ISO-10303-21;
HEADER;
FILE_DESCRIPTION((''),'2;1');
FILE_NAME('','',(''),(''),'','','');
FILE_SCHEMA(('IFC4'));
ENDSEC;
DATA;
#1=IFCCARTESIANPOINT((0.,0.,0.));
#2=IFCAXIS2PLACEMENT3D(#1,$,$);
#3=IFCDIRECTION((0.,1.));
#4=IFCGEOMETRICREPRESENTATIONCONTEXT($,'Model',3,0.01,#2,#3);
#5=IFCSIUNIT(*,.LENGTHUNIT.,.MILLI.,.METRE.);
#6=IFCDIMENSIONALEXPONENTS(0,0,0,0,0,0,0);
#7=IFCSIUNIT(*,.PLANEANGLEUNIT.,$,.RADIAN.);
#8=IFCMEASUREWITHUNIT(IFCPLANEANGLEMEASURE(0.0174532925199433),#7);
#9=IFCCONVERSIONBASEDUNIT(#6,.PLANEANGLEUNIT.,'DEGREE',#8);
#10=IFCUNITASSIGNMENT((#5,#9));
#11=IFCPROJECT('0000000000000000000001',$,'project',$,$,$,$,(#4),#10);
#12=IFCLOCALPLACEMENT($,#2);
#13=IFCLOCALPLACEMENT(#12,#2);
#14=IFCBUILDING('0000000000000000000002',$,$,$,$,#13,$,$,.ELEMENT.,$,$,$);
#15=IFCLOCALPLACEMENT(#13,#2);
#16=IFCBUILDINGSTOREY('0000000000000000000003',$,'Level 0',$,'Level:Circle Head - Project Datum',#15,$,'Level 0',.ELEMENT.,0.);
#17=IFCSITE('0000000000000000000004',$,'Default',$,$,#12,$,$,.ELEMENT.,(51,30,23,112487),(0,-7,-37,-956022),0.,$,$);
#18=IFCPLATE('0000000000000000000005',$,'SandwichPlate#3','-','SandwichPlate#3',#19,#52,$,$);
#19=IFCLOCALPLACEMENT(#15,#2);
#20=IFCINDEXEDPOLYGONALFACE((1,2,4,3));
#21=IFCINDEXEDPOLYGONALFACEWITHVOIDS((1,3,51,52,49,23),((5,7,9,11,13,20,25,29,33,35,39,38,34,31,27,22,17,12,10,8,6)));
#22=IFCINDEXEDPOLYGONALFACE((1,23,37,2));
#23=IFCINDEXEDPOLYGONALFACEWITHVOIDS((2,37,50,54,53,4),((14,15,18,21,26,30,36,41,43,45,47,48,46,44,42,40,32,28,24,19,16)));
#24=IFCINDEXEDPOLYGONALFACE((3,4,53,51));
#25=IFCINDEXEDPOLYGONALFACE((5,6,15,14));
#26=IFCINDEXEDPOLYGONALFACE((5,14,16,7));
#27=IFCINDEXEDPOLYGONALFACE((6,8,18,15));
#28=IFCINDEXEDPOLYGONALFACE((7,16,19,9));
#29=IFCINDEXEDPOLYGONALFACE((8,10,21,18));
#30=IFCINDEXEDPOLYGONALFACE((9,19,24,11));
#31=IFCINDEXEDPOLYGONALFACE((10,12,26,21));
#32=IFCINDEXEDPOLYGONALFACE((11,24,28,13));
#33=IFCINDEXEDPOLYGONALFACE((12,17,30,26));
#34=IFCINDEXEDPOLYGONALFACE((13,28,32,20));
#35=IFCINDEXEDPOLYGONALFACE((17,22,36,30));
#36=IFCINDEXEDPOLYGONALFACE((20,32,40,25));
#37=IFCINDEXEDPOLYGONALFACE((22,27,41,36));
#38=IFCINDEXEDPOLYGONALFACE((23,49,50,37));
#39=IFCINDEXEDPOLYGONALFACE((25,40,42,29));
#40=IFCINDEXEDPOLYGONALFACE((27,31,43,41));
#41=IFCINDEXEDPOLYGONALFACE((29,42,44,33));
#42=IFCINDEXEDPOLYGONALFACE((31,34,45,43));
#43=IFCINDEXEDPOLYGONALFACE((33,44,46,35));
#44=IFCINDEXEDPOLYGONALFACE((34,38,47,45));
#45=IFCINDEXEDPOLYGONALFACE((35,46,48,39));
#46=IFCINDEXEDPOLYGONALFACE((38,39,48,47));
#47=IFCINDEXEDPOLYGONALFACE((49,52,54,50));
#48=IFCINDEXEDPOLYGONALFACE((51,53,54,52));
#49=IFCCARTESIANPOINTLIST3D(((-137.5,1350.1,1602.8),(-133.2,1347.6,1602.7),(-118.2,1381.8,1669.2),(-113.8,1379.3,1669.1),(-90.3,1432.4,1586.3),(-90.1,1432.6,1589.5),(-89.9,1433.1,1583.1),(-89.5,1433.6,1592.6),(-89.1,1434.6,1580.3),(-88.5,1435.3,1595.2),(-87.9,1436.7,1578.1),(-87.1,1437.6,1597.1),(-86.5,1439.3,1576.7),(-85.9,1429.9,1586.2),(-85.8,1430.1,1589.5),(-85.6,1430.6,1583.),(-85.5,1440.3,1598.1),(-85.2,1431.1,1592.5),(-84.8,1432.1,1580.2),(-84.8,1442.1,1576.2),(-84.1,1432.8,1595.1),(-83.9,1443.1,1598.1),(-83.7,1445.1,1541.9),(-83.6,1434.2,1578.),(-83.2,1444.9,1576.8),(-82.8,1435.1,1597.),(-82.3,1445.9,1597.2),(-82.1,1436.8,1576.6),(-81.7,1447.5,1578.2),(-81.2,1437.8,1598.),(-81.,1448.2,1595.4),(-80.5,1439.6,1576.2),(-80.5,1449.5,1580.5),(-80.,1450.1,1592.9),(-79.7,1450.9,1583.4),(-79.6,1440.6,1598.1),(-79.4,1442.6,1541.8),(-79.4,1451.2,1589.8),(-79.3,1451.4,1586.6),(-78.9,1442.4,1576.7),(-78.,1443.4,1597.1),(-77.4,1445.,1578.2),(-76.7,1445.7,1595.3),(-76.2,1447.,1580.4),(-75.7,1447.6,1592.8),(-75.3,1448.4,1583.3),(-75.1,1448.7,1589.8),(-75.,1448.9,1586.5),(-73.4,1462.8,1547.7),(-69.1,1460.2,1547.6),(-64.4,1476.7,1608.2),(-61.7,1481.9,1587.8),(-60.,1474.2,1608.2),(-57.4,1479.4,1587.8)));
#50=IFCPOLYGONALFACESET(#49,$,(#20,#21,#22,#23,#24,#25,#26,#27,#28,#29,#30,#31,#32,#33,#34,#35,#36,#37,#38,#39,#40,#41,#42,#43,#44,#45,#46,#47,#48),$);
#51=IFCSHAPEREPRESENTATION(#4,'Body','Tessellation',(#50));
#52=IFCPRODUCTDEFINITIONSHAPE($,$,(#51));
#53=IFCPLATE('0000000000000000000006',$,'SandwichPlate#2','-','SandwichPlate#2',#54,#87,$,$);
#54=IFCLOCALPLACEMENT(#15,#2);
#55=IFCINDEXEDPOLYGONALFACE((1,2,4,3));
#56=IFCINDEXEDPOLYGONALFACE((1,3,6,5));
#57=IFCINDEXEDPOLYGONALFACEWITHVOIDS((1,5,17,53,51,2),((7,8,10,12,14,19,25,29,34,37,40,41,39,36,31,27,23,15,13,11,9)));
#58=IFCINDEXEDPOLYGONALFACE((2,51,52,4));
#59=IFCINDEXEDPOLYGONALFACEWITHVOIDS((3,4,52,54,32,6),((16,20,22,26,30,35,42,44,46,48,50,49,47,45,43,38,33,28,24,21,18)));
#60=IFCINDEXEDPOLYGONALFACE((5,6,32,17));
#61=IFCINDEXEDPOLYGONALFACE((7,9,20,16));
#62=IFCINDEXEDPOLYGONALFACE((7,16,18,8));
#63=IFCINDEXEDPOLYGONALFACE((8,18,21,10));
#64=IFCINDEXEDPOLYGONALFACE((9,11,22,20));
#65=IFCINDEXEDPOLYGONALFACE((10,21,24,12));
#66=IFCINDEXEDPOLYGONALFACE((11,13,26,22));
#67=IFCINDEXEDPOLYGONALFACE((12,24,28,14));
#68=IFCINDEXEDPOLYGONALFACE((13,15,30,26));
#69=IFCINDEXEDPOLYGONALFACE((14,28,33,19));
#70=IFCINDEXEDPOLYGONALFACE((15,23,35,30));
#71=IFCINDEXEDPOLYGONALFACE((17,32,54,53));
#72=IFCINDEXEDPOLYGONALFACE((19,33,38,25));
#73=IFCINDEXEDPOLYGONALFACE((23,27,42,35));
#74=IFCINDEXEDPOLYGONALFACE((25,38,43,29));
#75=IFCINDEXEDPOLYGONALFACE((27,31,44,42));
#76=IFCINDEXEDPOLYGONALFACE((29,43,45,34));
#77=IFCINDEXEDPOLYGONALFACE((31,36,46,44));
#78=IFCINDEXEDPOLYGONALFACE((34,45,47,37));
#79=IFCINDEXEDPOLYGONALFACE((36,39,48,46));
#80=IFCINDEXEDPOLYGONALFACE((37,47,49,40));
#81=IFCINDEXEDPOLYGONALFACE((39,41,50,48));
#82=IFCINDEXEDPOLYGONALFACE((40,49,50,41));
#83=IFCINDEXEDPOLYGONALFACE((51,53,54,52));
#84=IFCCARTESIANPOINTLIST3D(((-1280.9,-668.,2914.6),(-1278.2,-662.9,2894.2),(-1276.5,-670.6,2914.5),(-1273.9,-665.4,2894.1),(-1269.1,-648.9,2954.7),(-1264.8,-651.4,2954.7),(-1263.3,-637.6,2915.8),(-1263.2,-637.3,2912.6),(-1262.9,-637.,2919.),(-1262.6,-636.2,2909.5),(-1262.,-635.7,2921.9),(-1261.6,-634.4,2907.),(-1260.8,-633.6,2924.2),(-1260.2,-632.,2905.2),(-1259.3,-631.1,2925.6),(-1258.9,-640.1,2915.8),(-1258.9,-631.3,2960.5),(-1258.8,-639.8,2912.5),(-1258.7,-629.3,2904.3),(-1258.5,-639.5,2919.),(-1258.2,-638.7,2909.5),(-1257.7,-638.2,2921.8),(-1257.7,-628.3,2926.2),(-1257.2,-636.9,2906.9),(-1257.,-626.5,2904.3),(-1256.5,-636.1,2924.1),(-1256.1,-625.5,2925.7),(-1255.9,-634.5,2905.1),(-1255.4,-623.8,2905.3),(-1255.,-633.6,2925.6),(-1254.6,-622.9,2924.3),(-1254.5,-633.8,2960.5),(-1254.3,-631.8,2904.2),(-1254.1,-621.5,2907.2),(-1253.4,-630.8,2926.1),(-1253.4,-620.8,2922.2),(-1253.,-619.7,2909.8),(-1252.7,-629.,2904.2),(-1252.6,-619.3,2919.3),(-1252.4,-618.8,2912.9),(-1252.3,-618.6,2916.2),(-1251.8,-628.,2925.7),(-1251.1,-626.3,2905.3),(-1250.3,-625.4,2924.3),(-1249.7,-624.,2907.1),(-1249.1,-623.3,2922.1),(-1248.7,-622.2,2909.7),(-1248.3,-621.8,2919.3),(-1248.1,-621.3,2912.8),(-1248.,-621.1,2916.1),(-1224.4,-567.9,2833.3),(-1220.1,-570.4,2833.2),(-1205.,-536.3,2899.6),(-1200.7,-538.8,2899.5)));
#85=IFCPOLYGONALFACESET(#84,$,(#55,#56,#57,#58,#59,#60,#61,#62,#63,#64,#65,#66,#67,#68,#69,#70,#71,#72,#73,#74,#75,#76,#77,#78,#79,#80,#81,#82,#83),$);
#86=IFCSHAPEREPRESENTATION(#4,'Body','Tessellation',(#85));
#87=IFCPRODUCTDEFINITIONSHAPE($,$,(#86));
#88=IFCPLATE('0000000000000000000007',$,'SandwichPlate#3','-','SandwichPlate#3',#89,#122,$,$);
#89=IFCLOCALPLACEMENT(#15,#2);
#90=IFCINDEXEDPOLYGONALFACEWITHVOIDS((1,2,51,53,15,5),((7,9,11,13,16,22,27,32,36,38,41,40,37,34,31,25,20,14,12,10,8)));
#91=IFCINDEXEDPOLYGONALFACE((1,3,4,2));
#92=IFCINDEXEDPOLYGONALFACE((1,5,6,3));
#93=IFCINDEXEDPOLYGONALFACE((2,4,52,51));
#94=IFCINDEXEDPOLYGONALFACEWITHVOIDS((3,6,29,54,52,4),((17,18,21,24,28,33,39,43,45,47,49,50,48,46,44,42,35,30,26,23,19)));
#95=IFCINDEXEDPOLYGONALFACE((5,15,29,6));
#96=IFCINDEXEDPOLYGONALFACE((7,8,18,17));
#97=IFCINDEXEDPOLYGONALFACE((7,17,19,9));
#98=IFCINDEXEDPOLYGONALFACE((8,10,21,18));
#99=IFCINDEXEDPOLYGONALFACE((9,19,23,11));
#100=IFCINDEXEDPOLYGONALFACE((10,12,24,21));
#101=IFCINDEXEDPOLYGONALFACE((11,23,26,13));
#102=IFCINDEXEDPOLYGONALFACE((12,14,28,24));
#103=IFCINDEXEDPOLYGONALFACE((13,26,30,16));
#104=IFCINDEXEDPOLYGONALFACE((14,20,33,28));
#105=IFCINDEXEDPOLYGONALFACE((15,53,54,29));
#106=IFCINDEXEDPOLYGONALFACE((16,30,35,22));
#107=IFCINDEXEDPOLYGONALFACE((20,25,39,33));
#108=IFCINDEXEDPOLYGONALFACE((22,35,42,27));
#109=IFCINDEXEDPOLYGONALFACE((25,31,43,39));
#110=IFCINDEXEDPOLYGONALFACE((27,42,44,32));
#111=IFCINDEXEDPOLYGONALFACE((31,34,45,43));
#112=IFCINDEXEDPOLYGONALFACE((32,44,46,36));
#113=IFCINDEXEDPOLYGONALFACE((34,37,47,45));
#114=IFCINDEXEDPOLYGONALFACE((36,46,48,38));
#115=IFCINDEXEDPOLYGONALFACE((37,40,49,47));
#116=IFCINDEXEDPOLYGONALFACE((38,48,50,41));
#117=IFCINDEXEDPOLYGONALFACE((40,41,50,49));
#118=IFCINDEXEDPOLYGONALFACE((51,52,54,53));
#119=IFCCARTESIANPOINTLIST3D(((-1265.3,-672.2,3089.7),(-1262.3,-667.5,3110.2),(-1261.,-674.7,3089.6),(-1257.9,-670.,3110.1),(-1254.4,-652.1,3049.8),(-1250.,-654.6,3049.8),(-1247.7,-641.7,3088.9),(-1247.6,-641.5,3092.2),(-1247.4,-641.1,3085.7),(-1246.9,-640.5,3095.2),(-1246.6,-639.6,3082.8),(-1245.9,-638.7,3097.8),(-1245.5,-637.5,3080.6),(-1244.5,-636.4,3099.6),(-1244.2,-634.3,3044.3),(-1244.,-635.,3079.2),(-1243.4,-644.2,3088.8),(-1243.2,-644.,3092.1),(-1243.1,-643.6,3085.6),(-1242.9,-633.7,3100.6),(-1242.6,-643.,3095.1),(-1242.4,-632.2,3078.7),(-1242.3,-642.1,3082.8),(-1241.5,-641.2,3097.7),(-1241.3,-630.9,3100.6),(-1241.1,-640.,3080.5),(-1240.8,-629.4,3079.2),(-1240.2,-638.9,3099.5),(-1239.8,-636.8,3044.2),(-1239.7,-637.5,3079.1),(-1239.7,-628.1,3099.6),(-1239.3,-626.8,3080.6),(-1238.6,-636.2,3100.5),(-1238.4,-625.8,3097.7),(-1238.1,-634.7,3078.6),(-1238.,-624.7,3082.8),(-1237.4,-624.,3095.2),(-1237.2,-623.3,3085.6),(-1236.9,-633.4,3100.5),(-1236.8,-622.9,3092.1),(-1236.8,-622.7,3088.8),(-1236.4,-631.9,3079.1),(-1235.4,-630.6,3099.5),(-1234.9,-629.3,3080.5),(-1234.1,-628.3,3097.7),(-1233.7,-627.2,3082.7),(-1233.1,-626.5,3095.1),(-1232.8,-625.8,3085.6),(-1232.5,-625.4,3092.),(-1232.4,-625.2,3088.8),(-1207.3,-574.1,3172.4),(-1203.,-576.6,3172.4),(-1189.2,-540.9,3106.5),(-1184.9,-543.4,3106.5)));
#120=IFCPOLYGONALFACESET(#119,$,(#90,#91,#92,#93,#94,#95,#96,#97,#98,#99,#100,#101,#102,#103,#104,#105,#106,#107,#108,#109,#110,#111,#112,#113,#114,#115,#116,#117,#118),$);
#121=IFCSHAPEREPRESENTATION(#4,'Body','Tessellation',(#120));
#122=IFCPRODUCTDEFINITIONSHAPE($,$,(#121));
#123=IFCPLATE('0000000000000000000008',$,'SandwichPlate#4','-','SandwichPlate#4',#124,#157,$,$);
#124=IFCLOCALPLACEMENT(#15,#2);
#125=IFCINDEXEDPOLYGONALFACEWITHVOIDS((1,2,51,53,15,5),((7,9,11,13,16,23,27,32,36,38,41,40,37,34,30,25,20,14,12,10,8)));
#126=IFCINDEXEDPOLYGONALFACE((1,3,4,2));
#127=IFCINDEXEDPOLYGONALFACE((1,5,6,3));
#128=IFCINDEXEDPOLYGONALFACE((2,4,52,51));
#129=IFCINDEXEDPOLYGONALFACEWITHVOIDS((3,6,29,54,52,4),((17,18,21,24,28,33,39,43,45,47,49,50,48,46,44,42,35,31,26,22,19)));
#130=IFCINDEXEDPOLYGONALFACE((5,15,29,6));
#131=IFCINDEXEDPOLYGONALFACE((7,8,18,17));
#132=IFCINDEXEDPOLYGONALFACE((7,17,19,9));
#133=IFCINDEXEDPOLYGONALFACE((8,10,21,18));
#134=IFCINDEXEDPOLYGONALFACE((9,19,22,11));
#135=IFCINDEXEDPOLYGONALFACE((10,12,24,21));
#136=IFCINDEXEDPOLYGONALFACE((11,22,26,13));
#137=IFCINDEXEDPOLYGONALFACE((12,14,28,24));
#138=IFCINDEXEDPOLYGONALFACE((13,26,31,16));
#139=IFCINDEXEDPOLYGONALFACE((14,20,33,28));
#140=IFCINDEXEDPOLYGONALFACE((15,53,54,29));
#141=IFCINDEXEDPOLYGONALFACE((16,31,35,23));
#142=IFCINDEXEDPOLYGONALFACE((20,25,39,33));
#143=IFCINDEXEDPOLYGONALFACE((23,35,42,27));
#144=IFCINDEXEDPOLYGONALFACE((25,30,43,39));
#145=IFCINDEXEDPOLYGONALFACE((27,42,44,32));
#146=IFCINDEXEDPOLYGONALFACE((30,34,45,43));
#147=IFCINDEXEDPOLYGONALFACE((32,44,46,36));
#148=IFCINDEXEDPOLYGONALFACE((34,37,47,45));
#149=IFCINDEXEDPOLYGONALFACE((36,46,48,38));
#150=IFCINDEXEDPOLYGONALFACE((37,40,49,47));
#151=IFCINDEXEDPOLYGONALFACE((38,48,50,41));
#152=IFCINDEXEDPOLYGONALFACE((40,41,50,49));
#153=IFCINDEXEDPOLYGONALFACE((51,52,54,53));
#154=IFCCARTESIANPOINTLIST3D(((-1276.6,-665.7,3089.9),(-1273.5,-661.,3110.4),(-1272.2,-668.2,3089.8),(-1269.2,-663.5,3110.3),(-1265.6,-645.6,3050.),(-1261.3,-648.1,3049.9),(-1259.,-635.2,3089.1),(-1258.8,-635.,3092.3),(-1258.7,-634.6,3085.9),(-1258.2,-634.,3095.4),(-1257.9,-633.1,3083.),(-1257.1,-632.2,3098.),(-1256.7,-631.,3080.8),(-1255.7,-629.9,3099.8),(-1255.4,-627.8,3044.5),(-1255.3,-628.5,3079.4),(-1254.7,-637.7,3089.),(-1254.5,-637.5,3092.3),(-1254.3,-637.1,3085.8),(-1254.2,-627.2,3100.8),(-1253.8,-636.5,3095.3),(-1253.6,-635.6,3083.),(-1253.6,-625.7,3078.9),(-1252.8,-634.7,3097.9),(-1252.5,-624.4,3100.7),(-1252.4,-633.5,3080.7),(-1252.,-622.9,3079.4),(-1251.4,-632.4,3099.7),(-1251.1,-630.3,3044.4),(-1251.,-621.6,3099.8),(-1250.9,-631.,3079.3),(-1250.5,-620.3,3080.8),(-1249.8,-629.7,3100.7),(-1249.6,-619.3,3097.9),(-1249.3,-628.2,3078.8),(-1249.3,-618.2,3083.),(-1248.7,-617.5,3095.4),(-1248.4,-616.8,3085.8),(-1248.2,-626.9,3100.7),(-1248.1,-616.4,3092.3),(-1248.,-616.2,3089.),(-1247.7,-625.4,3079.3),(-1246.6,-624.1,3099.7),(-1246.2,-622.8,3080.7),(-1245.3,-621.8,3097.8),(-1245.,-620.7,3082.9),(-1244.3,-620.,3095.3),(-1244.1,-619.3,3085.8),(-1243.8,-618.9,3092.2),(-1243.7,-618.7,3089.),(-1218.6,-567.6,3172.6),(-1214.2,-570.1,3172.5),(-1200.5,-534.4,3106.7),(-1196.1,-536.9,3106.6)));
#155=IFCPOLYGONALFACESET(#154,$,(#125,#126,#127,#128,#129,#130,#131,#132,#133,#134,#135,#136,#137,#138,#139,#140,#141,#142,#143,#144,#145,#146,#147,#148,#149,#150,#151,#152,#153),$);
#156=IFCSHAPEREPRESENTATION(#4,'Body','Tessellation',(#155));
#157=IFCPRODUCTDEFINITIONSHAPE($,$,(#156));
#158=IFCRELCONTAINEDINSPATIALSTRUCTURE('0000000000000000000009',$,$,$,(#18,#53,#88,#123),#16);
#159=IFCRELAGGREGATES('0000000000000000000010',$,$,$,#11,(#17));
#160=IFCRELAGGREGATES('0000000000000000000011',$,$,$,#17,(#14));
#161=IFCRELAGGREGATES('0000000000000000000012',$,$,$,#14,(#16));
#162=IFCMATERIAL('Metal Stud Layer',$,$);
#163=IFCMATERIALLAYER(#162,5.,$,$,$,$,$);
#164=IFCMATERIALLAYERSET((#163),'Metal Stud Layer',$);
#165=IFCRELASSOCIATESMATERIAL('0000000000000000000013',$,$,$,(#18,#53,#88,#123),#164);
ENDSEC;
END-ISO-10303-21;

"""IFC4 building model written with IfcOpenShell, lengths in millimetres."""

from ifc_helpers import new_model, entity, si_unit, converted_unit, direction, frame, origin, origin_with_axes, origin_2d_with_axis, place, context, project, spatial, polyline, circle, outline, extrude, material, layer, layer_set, element, save


model = new_model("IFC4")

# Units and contexts
model_context = context("Model", 3, precision=0.01, world=origin(), true_north=direction((0.0, 1.0)))
ifc_project = project(units=[si_unit("LENGTHUNIT", "METRE", prefix="MILLI"), converted_unit("PLANEANGLEUNIT", "DEGREE", entity("IfcPlaneAngleMeasure", 0.0174532925199433), si_unit("PLANEANGLEUNIT", "RADIAN"), dimensions=[0, 0, 0, 0, 0, 0, 0])], contexts=[model_context])

# Site, building, storey
site_placement = place(None, origin())
site = spatial("IfcSite", under=ifc_project, at=site_placement, Name="Default", CompositionType="ELEMENT", RefLatitude=(51, 30, 23, 112487), RefLongitude=(0, -7, -37, -956022), RefElevation=0.0)
building_placement = place(site_placement, origin())
building = spatial("IfcBuilding", under=site, at=building_placement, CompositionType="ELEMENT")
storey_placement = place(building_placement, origin())
storey = spatial("IfcBuildingStorey", under=building, at=storey_placement, Name="Level 0", ObjectType="Level:Circle Head - Project Datum", LongName="Level 0", CompositionType="ELEMENT", Elevation=0.0)

# Plates, openings
ifc_material_1 = material(Name="Metal Stud Layer")
ifc_layer_1 = layer(ifc_material_1, 5.0)
ifc_layer_set_1 = layer_set([ifc_layer_1], Name="Metal Stud Layer")
plate_1_placement = place(storey_placement, frame((-77.2, 1456.5, 1534.6), z_axis=(0.865935, -0.499948, -0.014432), x_axis=(0.254617, 0.415806, 0.873084)))
plate_1 = element("IfcPlate", 1, at=plate_1_placement, inside=storey, material=ifc_layer_set_1, Name="SandwichPlate#3", Description="-", ObjectType="SandwichPlate#3", context=model_context, shape_type="SweptSolid", body=[
    extrude(outline(polyline([(0.0, 0.0), (76.0, 0.0), (76.0, 140.0), (0.0, 140.0), (0.0, 0.0)])), origin_with_axes(), (0.0, 0.0, 1.0), 5.0),
])
opening_1_placement = place(plate_1_placement, frame((0.0, 0.0, 0.0), z_axis=(0.0, 0.0, 1.0), x_axis=(1.0, 0.0, 0.0)))
element("IfcOpeningElement", 2, at=opening_1_placement, cuts=plate_1, ObjectType="Opening", context=model_context, shape_type="SweptSolid", body=[
    extrude(outline(polyline([(0.0, 0.0), (15.0, 0.0), (0.0, 15.0), (0.0, 0.0)])), origin(), (0.0, 0.0, 1.0), 5.0),
])
opening_2_placement = place(plate_1_placement, frame((0.0, 0.0, 0.0), z_axis=(0.0, 0.0, 1.0), x_axis=(1.0, 0.0, 0.0)))
element("IfcOpeningElement", 3, at=opening_2_placement, cuts=plate_1, ObjectType="Opening", context=model_context, shape_type="SweptSolid", body=[
    extrude(outline(polyline([(76.0, 0.0), (76.0, 15.0), (61.0, 0.0), (76.0, 0.0)])), origin(), (0.0, 0.0, 1.0), 5.0),
])
opening_3_placement = place(plate_1_placement, frame((38.0, 40.0, -0.5), z_axis=(0.0, 0.0, 1.0), x_axis=(0.0, 1.0, 0.0)))
element("IfcOpeningElement", 4, at=opening_3_placement, cuts=plate_1, ObjectType="Opening", context=model_context, shape_type="SweptSolid", body=[
    extrude(circle(Radius=11.0, at=origin_2d_with_axis()), origin(), (0.0, 0.0, 1.0), 6.0),
])
plate_2_placement = place(storey_placement, frame((-1280.3, -676.8, 2901.4), z_axis=(-0.865935, 0.499948, 0.014432), x_axis=(0.254617, 0.415806, 0.873084)))
plate_2 = element("IfcPlate", 5, at=plate_2_placement, inside=storey, material=ifc_layer_set_1, Name="SandwichPlate#2", Description="-", ObjectType="SandwichPlate#2", context=model_context, shape_type="SweptSolid", body=[
    extrude(outline(polyline([(0.0, 0.0), (76.0, 0.0), (76.0, 140.0), (0.0, 140.0), (0.0, 0.0)])), origin_with_axes(), (0.0, 0.0, 1.0), 5.0),
])
opening_4_placement = place(plate_2_placement, frame((0.0, 0.0, 0.0), z_axis=(0.0, 0.0, 1.0), x_axis=(1.0, 0.0, 0.0)))
element("IfcOpeningElement", 6, at=opening_4_placement, cuts=plate_2, ObjectType="Opening", context=model_context, shape_type="SweptSolid", body=[
    extrude(outline(polyline([(0.0, 0.0), (15.0, 0.0), (0.0, 15.0), (0.0, 0.0)])), origin(), (0.0, 0.0, 1.0), 5.0),
])
opening_5_placement = place(plate_2_placement, frame((0.0, 0.0, 0.0), z_axis=(0.0, 0.0, 1.0), x_axis=(1.0, 0.0, 0.0)))
element("IfcOpeningElement", 7, at=opening_5_placement, cuts=plate_2, ObjectType="Opening", context=model_context, shape_type="SweptSolid", body=[
    extrude(outline(polyline([(76.0, 0.0), (76.0, 15.0), (61.0, 0.0), (76.0, 0.0)])), origin(), (0.0, 0.0, 1.0), 5.0),
])
opening_6_placement = place(plate_2_placement, frame((38.0, 40.0, -0.5), z_axis=(0.0, 0.0, 1.0), x_axis=(0.0, 1.0, 0.0)))
element("IfcOpeningElement", 8, at=opening_6_placement, cuts=plate_2, ObjectType="Opening", context=model_context, shape_type="SweptSolid", body=[
    extrude(circle(Radius=11.0, at=origin_2d_with_axis()), origin(), (0.0, 0.0, 1.0), 6.0),
])
plate_3_placement = place(storey_placement, frame((-1246.4, -648.0, 3036.7), z_axis=(-0.865935, 0.499948, 0.014432), x_axis=(-0.238139, -0.437501, 0.867112)))
plate_3 = element("IfcPlate", 9, at=plate_3_placement, inside=storey, material=ifc_layer_set_1, Name="SandwichPlate#3", Description="-", ObjectType="SandwichPlate#3", context=model_context, shape_type="SweptSolid", body=[
    extrude(outline(polyline([(0.0, 0.0), (76.0, 0.0), (76.0, 140.0), (0.0, 140.0), (0.0, 0.0)])), origin_with_axes(), (0.0, 0.0, 1.0), 5.0),
])
opening_7_placement = place(plate_3_placement, frame((0.0, 0.0, 0.0), z_axis=(0.0, 0.0, 1.0), x_axis=(1.0, 0.0, 0.0)))
element("IfcOpeningElement", 10, at=opening_7_placement, cuts=plate_3, ObjectType="Opening", context=model_context, shape_type="SweptSolid", body=[
    extrude(outline(polyline([(0.0, 0.0), (15.0, 0.0), (0.0, 15.0), (0.0, 0.0)])), origin(), (0.0, 0.0, 1.0), 5.0),
])
opening_8_placement = place(plate_3_placement, frame((0.0, 0.0, 0.0), z_axis=(0.0, 0.0, 1.0), x_axis=(1.0, 0.0, 0.0)))
element("IfcOpeningElement", 11, at=opening_8_placement, cuts=plate_3, ObjectType="Opening", context=model_context, shape_type="SweptSolid", body=[
    extrude(outline(polyline([(76.0, 0.0), (76.0, 15.0), (61.0, 0.0), (76.0, 0.0)])), origin(), (0.0, 0.0, 1.0), 5.0),
])
opening_9_placement = place(plate_3_placement, frame((38.0, 40.0, -0.5), z_axis=(0.0, 0.0, 1.0), x_axis=(0.0, 1.0, 0.0)))
element("IfcOpeningElement", 12, at=opening_9_placement, cuts=plate_3, ObjectType="Opening", context=model_context, shape_type="SweptSolid", body=[
    extrude(circle(Radius=11.0, at=origin_2d_with_axis()), origin(), (0.0, 0.0, 1.0), 6.0),
])
plate_4_placement = place(storey_placement, frame((-1257.7, -641.5, 3036.9), z_axis=(-0.865935, 0.499948, 0.014432), x_axis=(-0.238139, -0.437501, 0.867112)))
plate_4 = element("IfcPlate", 13, at=plate_4_placement, inside=storey, material=ifc_layer_set_1, Name="SandwichPlate#4", Description="-", ObjectType="SandwichPlate#4", context=model_context, shape_type="SweptSolid", body=[
    extrude(outline(polyline([(0.0, 0.0), (76.0, 0.0), (76.0, 140.0), (0.0, 140.0), (0.0, 0.0)])), origin_with_axes(), (0.0, 0.0, 1.0), 5.0),
])
opening_10_placement = place(plate_4_placement, frame((0.0, 0.0, 0.0), z_axis=(0.0, 0.0, 1.0), x_axis=(1.0, 0.0, 0.0)))
element("IfcOpeningElement", 14, at=opening_10_placement, cuts=plate_4, ObjectType="Opening", context=model_context, shape_type="SweptSolid", body=[
    extrude(outline(polyline([(0.0, 0.0), (15.0, 0.0), (0.0, 15.0), (0.0, 0.0)])), origin(), (0.0, 0.0, 1.0), 5.0),
])
opening_11_placement = place(plate_4_placement, frame((0.0, 0.0, 0.0), z_axis=(0.0, 0.0, 1.0), x_axis=(1.0, 0.0, 0.0)))
element("IfcOpeningElement", 15, at=opening_11_placement, cuts=plate_4, ObjectType="Opening", context=model_context, shape_type="SweptSolid", body=[
    extrude(outline(polyline([(76.0, 0.0), (76.0, 15.0), (61.0, 0.0), (76.0, 0.0)])), origin(), (0.0, 0.0, 1.0), 5.0),
])
opening_12_placement = place(plate_4_placement, frame((38.0, 40.0, -0.5), z_axis=(0.0, 0.0, 1.0), x_axis=(0.0, 1.0, 0.0)))
element("IfcOpeningElement", 16, at=opening_12_placement, cuts=plate_4, ObjectType="Opening", context=model_context, shape_type="SweptSolid", body=[
    extrude(circle(Radius=11.0, at=origin_2d_with_axis()), origin(), (0.0, 0.0, 1.0), 6.0),
])

save(model, "model.ifc")
